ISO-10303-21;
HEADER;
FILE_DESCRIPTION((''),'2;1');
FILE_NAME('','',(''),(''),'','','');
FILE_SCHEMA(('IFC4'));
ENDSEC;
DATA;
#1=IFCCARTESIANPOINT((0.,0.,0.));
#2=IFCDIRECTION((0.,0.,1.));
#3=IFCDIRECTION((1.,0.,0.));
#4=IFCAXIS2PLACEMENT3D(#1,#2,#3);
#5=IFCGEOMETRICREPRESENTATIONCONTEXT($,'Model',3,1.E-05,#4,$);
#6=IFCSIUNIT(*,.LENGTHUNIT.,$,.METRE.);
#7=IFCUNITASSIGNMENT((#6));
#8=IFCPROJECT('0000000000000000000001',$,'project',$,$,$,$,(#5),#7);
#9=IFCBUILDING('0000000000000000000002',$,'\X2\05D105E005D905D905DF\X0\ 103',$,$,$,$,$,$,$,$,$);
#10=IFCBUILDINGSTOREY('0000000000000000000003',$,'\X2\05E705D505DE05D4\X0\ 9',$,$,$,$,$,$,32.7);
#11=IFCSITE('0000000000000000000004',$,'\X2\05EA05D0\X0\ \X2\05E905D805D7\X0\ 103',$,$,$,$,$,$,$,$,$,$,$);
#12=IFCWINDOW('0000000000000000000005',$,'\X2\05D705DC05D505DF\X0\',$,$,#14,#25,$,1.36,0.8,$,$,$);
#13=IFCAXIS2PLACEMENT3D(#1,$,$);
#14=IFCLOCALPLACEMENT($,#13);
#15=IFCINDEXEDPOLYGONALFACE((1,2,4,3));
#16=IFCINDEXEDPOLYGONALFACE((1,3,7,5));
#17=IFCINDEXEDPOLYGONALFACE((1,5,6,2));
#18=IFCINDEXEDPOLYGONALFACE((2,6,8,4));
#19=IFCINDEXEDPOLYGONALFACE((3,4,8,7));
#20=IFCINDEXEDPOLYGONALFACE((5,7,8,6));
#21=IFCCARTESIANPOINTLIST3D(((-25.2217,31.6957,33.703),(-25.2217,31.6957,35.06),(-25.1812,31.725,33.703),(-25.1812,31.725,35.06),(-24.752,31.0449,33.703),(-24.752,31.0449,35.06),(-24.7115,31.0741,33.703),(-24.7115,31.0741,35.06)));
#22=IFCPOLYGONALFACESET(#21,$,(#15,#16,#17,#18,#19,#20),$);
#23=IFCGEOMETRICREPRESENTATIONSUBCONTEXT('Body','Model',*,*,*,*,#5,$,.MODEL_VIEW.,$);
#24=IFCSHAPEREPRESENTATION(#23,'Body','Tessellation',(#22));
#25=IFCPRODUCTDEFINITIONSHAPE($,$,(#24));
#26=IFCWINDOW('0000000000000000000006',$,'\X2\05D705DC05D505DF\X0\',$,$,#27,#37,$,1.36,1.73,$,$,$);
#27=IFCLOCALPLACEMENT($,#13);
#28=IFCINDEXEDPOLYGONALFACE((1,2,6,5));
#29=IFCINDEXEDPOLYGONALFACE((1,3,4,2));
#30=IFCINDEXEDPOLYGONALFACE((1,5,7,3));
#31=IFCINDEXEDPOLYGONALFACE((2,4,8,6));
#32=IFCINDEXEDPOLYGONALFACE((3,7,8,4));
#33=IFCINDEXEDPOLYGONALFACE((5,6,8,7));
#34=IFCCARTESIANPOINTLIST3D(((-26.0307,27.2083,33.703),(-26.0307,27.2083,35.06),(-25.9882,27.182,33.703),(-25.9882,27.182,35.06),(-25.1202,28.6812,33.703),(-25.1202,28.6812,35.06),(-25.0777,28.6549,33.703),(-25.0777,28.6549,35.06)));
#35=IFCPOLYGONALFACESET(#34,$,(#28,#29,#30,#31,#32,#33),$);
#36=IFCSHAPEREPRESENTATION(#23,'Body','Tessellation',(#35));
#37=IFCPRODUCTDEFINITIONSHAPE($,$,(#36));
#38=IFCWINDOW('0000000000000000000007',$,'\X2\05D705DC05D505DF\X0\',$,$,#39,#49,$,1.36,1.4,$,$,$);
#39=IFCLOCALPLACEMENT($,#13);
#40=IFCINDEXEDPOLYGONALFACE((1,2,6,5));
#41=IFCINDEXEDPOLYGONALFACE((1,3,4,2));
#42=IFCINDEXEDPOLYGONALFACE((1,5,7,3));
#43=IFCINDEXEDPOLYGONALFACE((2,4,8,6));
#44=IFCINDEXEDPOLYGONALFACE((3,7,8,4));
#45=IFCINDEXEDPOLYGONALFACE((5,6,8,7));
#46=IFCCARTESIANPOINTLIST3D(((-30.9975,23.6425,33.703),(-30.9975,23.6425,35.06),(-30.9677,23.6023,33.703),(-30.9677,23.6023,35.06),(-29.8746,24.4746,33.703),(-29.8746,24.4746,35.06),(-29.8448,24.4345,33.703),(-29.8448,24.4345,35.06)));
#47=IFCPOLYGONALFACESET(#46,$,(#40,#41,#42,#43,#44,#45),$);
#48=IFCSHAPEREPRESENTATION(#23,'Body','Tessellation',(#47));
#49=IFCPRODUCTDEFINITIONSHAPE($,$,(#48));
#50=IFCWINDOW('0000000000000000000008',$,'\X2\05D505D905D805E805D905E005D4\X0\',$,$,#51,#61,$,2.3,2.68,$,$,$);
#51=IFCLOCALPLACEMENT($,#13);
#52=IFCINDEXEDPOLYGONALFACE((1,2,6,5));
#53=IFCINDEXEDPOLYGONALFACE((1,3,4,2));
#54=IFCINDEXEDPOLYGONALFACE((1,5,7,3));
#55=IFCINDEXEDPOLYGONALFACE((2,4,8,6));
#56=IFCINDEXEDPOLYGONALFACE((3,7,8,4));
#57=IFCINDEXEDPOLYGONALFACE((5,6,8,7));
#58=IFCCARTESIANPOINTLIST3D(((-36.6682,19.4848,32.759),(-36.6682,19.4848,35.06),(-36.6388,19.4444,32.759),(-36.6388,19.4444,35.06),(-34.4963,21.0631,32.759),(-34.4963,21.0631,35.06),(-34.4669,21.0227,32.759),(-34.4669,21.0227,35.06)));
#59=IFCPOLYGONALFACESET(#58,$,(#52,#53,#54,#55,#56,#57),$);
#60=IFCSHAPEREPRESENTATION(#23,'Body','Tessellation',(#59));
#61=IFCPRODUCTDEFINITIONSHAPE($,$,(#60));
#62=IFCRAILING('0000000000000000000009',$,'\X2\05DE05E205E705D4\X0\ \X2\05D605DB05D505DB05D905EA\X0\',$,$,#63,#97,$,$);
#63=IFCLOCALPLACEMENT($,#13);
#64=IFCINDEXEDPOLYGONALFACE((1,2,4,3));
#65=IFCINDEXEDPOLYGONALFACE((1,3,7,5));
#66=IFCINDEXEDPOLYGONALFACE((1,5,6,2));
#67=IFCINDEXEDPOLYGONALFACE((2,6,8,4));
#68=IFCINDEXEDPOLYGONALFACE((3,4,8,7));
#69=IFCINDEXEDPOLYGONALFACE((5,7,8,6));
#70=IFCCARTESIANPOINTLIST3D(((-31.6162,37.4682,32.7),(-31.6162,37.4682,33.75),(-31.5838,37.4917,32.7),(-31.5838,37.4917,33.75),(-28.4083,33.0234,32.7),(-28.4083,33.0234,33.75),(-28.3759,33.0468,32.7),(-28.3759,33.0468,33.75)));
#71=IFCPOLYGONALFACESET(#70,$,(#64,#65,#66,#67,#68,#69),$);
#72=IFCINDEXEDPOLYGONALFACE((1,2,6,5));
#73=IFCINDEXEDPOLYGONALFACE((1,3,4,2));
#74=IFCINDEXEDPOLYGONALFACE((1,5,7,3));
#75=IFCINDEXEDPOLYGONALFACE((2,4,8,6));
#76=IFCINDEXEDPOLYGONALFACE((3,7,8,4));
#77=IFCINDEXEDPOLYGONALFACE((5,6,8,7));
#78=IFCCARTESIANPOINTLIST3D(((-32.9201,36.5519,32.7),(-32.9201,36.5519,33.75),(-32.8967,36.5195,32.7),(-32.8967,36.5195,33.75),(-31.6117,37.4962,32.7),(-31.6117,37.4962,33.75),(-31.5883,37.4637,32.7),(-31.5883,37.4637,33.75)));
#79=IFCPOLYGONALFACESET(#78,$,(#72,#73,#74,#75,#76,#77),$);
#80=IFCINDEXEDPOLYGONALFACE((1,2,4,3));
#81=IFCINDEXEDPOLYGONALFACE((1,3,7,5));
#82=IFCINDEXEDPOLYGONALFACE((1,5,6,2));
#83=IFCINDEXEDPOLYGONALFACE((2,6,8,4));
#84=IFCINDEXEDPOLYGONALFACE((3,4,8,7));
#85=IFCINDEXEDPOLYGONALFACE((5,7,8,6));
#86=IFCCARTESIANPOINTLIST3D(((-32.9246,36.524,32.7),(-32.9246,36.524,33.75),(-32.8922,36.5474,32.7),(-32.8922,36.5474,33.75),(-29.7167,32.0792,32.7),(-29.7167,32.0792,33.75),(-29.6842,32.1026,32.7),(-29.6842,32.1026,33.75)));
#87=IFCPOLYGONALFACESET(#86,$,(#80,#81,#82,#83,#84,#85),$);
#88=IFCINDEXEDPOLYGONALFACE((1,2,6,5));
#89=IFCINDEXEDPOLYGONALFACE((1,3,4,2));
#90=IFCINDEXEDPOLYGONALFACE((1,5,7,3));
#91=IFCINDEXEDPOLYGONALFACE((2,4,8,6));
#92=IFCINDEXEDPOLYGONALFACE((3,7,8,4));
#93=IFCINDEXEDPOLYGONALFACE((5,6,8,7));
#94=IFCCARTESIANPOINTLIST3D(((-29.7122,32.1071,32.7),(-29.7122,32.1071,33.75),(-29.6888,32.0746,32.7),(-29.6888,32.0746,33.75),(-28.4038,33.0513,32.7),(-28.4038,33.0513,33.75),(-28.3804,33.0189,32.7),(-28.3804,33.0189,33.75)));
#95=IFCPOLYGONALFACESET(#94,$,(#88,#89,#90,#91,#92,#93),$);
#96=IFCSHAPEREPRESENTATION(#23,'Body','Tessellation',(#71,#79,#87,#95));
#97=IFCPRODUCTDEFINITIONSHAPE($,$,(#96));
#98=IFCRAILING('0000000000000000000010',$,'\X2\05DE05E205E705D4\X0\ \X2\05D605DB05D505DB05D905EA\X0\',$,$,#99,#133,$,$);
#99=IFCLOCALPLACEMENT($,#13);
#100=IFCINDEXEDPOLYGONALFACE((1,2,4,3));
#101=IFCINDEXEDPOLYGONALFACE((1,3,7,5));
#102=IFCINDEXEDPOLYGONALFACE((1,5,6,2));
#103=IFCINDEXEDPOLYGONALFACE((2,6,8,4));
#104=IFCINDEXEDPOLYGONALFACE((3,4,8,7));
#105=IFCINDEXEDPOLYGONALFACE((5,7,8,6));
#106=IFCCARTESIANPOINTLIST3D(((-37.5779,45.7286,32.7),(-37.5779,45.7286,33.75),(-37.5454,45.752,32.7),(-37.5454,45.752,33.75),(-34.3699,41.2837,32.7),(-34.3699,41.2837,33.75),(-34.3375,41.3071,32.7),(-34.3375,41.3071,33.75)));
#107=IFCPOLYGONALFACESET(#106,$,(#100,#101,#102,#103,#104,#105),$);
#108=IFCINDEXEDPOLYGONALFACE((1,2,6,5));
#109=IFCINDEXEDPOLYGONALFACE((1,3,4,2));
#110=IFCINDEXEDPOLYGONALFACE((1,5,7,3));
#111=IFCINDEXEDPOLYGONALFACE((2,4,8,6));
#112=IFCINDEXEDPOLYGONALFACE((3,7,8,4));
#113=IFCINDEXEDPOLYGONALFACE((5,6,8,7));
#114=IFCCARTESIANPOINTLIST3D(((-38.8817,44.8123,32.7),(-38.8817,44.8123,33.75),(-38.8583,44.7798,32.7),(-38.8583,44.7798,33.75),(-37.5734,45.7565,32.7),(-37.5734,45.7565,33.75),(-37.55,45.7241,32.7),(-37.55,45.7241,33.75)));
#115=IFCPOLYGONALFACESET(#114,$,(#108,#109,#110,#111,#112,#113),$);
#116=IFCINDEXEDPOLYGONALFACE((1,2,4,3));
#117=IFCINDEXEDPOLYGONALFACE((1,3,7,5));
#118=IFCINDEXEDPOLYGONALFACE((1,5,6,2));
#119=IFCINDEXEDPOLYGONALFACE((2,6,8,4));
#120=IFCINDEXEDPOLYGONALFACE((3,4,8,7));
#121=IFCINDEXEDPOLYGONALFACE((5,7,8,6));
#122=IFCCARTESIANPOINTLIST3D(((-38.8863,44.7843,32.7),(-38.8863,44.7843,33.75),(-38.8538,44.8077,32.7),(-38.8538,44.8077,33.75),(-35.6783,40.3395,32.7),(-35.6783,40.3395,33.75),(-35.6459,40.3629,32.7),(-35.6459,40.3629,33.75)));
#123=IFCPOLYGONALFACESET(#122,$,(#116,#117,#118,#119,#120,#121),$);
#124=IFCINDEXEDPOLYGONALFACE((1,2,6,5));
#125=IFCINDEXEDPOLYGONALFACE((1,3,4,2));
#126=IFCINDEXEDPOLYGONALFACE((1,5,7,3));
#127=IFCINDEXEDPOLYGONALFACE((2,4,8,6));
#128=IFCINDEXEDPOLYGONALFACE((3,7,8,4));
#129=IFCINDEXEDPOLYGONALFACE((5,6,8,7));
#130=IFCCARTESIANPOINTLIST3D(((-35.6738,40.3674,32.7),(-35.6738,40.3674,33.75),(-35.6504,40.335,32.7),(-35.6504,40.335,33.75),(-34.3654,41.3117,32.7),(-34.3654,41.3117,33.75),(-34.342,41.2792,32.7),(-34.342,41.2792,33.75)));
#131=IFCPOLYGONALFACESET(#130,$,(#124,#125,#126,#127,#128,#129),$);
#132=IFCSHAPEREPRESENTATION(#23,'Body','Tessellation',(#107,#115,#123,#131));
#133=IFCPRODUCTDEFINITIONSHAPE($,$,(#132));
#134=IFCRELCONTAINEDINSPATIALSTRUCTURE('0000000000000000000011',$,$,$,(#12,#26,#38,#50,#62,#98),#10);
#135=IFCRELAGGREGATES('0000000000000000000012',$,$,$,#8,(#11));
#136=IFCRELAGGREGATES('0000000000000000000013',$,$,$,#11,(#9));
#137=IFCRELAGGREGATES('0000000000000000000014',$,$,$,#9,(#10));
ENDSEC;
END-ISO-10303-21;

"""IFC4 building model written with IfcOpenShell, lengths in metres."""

from ifc_helpers import new_model, si_unit, frame, origin_with_axes, context, subcontext, project, spatial, polyline, outline, extrude, element, save


model = new_model("IFC4")

# Units and contexts
model_context = context("Model", 3, precision=1e-05, world=origin_with_axes())
body_context = subcontext(model_context, "Body", "Model", "MODEL_VIEW")
ifc_project = project(units=[si_unit("LENGTHUNIT", "METRE")], contexts=[model_context])

# Site, building, storey
site = spatial("IfcSite", under=ifc_project, Name="תא שטח 103")
building = spatial("IfcBuilding", under=site, Name="בניין 103")
storey = spatial("IfcBuildingStorey", under=building, Name="קומה 9", Elevation=32.7)

# Windows
element("IfcWindow", 1, inside=storey, Name="חלון", OverallHeight=1.36, OverallWidth=0.8, context=body_context, shape_type="SweptSolid", body=[
    extrude(outline(polyline([(-25.2217, 31.6957), (-24.752, 31.0449), (-24.7115, 31.0741), (-25.1812, 31.725), (-25.2217, 31.6957)])), frame((0.0, 0.0, 33.703)), (0.0, 0.0, 1.0), 1.357),
])
element("IfcWindow", 2, inside=storey, Name="חלון", OverallHeight=1.36, OverallWidth=1.73, context=body_context, shape_type="SweptSolid", body=[
    extrude(outline(polyline([(-25.1202, 28.6812), (-26.0307, 27.2083), (-25.9882, 27.182), (-25.0777, 28.6549), (-25.1202, 28.6812)])), frame((0.0, 0.0, 33.703)), (0.0, 0.0, 1.0), 1.357),
])
element("IfcWindow", 3, inside=storey, Name="חלון", OverallHeight=1.36, OverallWidth=1.4, context=body_context, shape_type="SweptSolid", body=[
    extrude(outline(polyline([(-29.8746, 24.4746), (-30.9975, 23.6425), (-30.9677, 23.6023), (-29.8448, 24.4345), (-29.8746, 24.4746)])), frame((0.0, 0.0, 33.703)), (0.0, 0.0, 1.0), 1.357),
])
element("IfcWindow", 4, inside=storey, Name="ויטרינה", OverallHeight=2.3, OverallWidth=2.68, context=body_context, shape_type="SweptSolid", body=[
    extrude(outline(polyline([(-34.4963, 21.0631), (-36.6682, 19.4848), (-36.6388, 19.4444), (-34.4669, 21.0227), (-34.4963, 21.0631)])), frame((0.0, 0.0, 32.759)), (0.0, 0.0, 1.0), 2.301),
])

# Railings
element("IfcRailing", 5, inside=storey, Name="מעקה זכוכית", context=body_context, shape_type="SweptSolid", body=[
    extrude(outline(polyline([(-28.3759, 33.0468), (-31.5838, 37.4917), (-31.6162, 37.4682), (-28.4083, 33.0234), (-28.3759, 33.0468)])), frame((0.0, 0.0, 32.7)), (0.0, 0.0, 1.0), 1.05),
    extrude(outline(polyline([(-31.6117, 37.4962), (-32.9201, 36.5519), (-32.8967, 36.5195), (-31.5883, 37.4637), (-31.6117, 37.4962)])), frame((0.0, 0.0, 32.7)), (0.0, 0.0, 1.0), 1.05),
    extrude(outline(polyline([(-32.9246, 36.524), (-29.7167, 32.0792), (-29.6842, 32.1026), (-32.8922, 36.5474), (-32.9246, 36.524)])), frame((0.0, 0.0, 32.7)), (0.0, 0.0, 1.0), 1.05),
    extrude(outline(polyline([(-29.6888, 32.0746), (-28.3804, 33.0189), (-28.4038, 33.0513), (-29.7122, 32.1071), (-29.6888, 32.0746)])), frame((0.0, 0.0, 32.7)), (0.0, 0.0, 1.0), 1.05),
])
element("IfcRailing", 6, inside=storey, Name="מעקה זכוכית", context=body_context, shape_type="SweptSolid", body=[
    extrude(outline(polyline([(-34.3375, 41.3071), (-37.5454, 45.752), (-37.5779, 45.7286), (-34.3699, 41.2837), (-34.3375, 41.3071)])), frame((0.0, 0.0, 32.7)), (0.0, 0.0, 1.0), 1.05),
    extrude(outline(polyline([(-37.5734, 45.7565), (-38.8817, 44.8123), (-38.8583, 44.7798), (-37.55, 45.7241), (-37.5734, 45.7565)])), frame((0.0, 0.0, 32.7)), (0.0, 0.0, 1.0), 1.05),
    extrude(outline(polyline([(-38.8863, 44.7843), (-35.6783, 40.3395), (-35.6459, 40.3629), (-38.8538, 44.8077), (-38.8863, 44.7843)])), frame((0.0, 0.0, 32.7)), (0.0, 0.0, 1.0), 1.05),
    extrude(outline(polyline([(-35.6504, 40.335), (-34.342, 41.2792), (-34.3654, 41.3117), (-35.6738, 40.3674), (-35.6504, 40.335)])), frame((0.0, 0.0, 32.7)), (0.0, 0.0, 1.0), 1.05),
])

save(model, "model.ifc")
